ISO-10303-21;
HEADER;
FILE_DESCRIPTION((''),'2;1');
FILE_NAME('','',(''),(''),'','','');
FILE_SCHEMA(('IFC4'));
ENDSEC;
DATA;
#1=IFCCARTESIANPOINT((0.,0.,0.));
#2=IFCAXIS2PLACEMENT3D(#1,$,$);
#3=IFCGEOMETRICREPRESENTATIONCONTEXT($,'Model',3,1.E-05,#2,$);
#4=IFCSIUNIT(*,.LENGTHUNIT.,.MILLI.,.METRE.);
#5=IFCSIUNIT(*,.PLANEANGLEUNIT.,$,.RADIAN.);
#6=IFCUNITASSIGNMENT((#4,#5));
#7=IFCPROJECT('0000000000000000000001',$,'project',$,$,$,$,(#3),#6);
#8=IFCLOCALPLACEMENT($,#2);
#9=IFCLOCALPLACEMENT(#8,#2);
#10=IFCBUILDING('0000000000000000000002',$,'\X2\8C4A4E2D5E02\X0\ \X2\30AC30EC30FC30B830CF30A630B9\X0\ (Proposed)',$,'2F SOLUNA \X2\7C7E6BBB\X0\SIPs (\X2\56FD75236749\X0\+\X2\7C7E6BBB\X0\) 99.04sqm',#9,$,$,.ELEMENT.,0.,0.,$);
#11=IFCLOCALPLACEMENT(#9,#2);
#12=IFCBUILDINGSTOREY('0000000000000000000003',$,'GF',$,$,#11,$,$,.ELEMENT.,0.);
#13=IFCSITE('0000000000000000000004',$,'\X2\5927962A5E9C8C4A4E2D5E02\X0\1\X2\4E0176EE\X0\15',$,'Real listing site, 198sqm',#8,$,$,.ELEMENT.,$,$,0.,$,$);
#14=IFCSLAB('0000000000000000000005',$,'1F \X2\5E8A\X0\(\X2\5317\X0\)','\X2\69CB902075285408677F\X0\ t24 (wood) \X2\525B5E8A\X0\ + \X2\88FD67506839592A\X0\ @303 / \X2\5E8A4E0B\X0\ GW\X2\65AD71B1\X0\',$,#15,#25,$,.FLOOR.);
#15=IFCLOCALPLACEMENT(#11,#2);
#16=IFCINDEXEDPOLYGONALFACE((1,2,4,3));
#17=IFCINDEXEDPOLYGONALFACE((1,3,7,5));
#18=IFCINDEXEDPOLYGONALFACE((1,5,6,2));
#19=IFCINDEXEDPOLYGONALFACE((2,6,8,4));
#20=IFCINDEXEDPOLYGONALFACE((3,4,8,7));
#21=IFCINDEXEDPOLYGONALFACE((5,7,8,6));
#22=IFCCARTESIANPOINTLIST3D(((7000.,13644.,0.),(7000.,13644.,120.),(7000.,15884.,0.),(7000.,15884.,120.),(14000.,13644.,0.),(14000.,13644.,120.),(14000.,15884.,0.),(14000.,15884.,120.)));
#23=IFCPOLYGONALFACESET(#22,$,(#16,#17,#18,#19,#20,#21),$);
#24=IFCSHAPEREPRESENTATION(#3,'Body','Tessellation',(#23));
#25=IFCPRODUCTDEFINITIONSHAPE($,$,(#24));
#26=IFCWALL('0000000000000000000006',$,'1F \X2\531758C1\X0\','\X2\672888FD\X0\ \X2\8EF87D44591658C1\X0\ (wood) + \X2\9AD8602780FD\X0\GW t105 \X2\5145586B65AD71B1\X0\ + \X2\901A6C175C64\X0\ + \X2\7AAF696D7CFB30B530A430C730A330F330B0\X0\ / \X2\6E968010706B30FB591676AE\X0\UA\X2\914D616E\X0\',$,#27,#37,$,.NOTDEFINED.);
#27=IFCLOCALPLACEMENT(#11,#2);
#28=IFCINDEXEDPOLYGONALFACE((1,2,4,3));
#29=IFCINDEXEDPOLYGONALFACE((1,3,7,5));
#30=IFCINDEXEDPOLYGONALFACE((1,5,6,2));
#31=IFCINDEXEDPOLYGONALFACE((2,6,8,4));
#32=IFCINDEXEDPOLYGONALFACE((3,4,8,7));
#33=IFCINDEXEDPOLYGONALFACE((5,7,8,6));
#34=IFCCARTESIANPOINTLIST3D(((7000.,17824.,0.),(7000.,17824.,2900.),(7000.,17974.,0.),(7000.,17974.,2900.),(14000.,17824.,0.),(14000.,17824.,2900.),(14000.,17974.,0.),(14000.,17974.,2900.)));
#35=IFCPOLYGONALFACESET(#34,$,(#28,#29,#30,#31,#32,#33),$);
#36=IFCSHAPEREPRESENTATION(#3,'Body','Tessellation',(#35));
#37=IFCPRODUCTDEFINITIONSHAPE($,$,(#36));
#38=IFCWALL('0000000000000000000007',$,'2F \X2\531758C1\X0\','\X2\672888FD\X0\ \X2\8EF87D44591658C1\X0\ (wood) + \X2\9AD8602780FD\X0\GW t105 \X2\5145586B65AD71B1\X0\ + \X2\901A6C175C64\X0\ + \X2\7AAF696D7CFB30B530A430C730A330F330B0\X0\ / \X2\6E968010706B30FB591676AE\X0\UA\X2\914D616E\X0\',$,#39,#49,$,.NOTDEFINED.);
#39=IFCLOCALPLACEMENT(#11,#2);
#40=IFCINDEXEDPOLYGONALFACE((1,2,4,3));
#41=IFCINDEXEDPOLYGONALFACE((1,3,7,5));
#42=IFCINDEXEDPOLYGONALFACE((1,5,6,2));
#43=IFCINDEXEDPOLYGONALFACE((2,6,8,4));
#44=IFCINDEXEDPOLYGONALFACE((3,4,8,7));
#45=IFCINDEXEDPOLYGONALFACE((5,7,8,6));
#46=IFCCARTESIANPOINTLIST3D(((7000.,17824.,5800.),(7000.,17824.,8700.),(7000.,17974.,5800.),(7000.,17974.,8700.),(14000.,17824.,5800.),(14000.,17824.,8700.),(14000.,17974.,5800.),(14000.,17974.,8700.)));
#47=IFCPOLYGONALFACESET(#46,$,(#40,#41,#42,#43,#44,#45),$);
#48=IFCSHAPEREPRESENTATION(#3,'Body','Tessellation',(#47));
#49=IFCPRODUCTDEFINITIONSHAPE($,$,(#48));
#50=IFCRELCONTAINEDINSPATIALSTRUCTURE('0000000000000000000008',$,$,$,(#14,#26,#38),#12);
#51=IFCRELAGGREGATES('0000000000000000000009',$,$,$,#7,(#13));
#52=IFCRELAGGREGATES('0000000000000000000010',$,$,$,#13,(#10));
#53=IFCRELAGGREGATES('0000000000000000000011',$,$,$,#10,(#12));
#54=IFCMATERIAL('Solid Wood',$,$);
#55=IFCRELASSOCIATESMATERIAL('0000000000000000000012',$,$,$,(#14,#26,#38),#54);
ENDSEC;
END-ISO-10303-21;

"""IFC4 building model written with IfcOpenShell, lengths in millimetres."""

from ifc_helpers import new_model, si_unit, frame, frame_2d, origin, place, context, project, spatial, rectangle, extrude, material, element, save


model = new_model("IFC4")

# Units and contexts
model_context = context("Model", 3, precision=1e-05, world=origin())
ifc_project = project(units=[si_unit("LENGTHUNIT", "METRE", prefix="MILLI"), si_unit("PLANEANGLEUNIT", "RADIAN")], contexts=[model_context])

# Site, building, storey
site_placement = place(None, origin())
site = spatial("IfcSite", under=ifc_project, at=site_placement, Name="大阪府豊中市1丁目15", ObjectType="Real listing site, 198sqm", CompositionType="ELEMENT", RefElevation=0.0)
building_placement = place(site_placement, origin())
building = spatial("IfcBuilding", under=site, at=building_placement, Name="豊中市 ガレージハウス (Proposed)", ObjectType="2F SOLUNA 籾殻SIPs (国産杉+籾殻) 99.04sqm", CompositionType="ELEMENT", ElevationOfRefHeight=0.0, ElevationOfTerrain=0.0)
storey_placement = place(building_placement, origin())
storey = spatial("IfcBuildingStorey", under=building, at=storey_placement, Name="GF", CompositionType="ELEMENT", Elevation=0.0)

# Slab
ifc_material_1 = material(Name="Solid Wood")
slab_1_placement = place(storey_placement, frame((3500.0, 6822.0, 0.0)))
element("IfcSlab", 1, at=slab_1_placement, inside=storey, material=ifc_material_1, Name="1F 床(北)", Description="構造用合板 t24 (wood) 剛床 + 製材根太 @303 / 床下 GW断熱", PredefinedType="FLOOR", context=model_context, shape_type="SweptSolid", body=[
    extrude(rectangle(XDim=7000.0, YDim=2240.0, at=frame_2d((3500.0, 1120.0))), frame((3500.0, 6822.0, 0.0)), (0.0, 0.0, 1.0), 120.0),
])

# Wall
wall_1_placement = place(storey_placement, frame((3500.0, 8912.0, 0.0)))
element("IfcWall", 2, at=wall_1_placement, inside=storey, material=ifc_material_1, Name="1F 北壁", Description="木製 軸組外壁 (wood) + 高性能GW t105 充填断熱 + 通気層 + 窯業系サイディング / 準耐火・外皮UA配慮", PredefinedType="NOTDEFINED", context=model_context, shape_type="SweptSolid", body=[
    extrude(rectangle(XDim=7000.0, YDim=150.0, at=frame_2d((3500.0, 75.0))), frame((3500.0, 8912.0, 0.0)), (0.0, 0.0, 1.0), 2900.0),
])

# Wall
wall_2_placement = place(storey_placement, frame((3500.0, 8912.0, 2900.0)))
element("IfcWall", 3, at=wall_2_placement, inside=storey, material=ifc_material_1, Name="2F 北壁", Description="木製 軸組外壁 (wood) + 高性能GW t105 充填断熱 + 通気層 + 窯業系サイディング / 準耐火・外皮UA配慮", PredefinedType="NOTDEFINED", context=model_context, shape_type="SweptSolid", body=[
    extrude(rectangle(XDim=7000.0, YDim=150.0, at=frame_2d((3500.0, 75.0))), frame((3500.0, 8912.0, 2900.0)), (0.0, 0.0, 1.0), 2900.0),
])

save(model, "model.ifc")
